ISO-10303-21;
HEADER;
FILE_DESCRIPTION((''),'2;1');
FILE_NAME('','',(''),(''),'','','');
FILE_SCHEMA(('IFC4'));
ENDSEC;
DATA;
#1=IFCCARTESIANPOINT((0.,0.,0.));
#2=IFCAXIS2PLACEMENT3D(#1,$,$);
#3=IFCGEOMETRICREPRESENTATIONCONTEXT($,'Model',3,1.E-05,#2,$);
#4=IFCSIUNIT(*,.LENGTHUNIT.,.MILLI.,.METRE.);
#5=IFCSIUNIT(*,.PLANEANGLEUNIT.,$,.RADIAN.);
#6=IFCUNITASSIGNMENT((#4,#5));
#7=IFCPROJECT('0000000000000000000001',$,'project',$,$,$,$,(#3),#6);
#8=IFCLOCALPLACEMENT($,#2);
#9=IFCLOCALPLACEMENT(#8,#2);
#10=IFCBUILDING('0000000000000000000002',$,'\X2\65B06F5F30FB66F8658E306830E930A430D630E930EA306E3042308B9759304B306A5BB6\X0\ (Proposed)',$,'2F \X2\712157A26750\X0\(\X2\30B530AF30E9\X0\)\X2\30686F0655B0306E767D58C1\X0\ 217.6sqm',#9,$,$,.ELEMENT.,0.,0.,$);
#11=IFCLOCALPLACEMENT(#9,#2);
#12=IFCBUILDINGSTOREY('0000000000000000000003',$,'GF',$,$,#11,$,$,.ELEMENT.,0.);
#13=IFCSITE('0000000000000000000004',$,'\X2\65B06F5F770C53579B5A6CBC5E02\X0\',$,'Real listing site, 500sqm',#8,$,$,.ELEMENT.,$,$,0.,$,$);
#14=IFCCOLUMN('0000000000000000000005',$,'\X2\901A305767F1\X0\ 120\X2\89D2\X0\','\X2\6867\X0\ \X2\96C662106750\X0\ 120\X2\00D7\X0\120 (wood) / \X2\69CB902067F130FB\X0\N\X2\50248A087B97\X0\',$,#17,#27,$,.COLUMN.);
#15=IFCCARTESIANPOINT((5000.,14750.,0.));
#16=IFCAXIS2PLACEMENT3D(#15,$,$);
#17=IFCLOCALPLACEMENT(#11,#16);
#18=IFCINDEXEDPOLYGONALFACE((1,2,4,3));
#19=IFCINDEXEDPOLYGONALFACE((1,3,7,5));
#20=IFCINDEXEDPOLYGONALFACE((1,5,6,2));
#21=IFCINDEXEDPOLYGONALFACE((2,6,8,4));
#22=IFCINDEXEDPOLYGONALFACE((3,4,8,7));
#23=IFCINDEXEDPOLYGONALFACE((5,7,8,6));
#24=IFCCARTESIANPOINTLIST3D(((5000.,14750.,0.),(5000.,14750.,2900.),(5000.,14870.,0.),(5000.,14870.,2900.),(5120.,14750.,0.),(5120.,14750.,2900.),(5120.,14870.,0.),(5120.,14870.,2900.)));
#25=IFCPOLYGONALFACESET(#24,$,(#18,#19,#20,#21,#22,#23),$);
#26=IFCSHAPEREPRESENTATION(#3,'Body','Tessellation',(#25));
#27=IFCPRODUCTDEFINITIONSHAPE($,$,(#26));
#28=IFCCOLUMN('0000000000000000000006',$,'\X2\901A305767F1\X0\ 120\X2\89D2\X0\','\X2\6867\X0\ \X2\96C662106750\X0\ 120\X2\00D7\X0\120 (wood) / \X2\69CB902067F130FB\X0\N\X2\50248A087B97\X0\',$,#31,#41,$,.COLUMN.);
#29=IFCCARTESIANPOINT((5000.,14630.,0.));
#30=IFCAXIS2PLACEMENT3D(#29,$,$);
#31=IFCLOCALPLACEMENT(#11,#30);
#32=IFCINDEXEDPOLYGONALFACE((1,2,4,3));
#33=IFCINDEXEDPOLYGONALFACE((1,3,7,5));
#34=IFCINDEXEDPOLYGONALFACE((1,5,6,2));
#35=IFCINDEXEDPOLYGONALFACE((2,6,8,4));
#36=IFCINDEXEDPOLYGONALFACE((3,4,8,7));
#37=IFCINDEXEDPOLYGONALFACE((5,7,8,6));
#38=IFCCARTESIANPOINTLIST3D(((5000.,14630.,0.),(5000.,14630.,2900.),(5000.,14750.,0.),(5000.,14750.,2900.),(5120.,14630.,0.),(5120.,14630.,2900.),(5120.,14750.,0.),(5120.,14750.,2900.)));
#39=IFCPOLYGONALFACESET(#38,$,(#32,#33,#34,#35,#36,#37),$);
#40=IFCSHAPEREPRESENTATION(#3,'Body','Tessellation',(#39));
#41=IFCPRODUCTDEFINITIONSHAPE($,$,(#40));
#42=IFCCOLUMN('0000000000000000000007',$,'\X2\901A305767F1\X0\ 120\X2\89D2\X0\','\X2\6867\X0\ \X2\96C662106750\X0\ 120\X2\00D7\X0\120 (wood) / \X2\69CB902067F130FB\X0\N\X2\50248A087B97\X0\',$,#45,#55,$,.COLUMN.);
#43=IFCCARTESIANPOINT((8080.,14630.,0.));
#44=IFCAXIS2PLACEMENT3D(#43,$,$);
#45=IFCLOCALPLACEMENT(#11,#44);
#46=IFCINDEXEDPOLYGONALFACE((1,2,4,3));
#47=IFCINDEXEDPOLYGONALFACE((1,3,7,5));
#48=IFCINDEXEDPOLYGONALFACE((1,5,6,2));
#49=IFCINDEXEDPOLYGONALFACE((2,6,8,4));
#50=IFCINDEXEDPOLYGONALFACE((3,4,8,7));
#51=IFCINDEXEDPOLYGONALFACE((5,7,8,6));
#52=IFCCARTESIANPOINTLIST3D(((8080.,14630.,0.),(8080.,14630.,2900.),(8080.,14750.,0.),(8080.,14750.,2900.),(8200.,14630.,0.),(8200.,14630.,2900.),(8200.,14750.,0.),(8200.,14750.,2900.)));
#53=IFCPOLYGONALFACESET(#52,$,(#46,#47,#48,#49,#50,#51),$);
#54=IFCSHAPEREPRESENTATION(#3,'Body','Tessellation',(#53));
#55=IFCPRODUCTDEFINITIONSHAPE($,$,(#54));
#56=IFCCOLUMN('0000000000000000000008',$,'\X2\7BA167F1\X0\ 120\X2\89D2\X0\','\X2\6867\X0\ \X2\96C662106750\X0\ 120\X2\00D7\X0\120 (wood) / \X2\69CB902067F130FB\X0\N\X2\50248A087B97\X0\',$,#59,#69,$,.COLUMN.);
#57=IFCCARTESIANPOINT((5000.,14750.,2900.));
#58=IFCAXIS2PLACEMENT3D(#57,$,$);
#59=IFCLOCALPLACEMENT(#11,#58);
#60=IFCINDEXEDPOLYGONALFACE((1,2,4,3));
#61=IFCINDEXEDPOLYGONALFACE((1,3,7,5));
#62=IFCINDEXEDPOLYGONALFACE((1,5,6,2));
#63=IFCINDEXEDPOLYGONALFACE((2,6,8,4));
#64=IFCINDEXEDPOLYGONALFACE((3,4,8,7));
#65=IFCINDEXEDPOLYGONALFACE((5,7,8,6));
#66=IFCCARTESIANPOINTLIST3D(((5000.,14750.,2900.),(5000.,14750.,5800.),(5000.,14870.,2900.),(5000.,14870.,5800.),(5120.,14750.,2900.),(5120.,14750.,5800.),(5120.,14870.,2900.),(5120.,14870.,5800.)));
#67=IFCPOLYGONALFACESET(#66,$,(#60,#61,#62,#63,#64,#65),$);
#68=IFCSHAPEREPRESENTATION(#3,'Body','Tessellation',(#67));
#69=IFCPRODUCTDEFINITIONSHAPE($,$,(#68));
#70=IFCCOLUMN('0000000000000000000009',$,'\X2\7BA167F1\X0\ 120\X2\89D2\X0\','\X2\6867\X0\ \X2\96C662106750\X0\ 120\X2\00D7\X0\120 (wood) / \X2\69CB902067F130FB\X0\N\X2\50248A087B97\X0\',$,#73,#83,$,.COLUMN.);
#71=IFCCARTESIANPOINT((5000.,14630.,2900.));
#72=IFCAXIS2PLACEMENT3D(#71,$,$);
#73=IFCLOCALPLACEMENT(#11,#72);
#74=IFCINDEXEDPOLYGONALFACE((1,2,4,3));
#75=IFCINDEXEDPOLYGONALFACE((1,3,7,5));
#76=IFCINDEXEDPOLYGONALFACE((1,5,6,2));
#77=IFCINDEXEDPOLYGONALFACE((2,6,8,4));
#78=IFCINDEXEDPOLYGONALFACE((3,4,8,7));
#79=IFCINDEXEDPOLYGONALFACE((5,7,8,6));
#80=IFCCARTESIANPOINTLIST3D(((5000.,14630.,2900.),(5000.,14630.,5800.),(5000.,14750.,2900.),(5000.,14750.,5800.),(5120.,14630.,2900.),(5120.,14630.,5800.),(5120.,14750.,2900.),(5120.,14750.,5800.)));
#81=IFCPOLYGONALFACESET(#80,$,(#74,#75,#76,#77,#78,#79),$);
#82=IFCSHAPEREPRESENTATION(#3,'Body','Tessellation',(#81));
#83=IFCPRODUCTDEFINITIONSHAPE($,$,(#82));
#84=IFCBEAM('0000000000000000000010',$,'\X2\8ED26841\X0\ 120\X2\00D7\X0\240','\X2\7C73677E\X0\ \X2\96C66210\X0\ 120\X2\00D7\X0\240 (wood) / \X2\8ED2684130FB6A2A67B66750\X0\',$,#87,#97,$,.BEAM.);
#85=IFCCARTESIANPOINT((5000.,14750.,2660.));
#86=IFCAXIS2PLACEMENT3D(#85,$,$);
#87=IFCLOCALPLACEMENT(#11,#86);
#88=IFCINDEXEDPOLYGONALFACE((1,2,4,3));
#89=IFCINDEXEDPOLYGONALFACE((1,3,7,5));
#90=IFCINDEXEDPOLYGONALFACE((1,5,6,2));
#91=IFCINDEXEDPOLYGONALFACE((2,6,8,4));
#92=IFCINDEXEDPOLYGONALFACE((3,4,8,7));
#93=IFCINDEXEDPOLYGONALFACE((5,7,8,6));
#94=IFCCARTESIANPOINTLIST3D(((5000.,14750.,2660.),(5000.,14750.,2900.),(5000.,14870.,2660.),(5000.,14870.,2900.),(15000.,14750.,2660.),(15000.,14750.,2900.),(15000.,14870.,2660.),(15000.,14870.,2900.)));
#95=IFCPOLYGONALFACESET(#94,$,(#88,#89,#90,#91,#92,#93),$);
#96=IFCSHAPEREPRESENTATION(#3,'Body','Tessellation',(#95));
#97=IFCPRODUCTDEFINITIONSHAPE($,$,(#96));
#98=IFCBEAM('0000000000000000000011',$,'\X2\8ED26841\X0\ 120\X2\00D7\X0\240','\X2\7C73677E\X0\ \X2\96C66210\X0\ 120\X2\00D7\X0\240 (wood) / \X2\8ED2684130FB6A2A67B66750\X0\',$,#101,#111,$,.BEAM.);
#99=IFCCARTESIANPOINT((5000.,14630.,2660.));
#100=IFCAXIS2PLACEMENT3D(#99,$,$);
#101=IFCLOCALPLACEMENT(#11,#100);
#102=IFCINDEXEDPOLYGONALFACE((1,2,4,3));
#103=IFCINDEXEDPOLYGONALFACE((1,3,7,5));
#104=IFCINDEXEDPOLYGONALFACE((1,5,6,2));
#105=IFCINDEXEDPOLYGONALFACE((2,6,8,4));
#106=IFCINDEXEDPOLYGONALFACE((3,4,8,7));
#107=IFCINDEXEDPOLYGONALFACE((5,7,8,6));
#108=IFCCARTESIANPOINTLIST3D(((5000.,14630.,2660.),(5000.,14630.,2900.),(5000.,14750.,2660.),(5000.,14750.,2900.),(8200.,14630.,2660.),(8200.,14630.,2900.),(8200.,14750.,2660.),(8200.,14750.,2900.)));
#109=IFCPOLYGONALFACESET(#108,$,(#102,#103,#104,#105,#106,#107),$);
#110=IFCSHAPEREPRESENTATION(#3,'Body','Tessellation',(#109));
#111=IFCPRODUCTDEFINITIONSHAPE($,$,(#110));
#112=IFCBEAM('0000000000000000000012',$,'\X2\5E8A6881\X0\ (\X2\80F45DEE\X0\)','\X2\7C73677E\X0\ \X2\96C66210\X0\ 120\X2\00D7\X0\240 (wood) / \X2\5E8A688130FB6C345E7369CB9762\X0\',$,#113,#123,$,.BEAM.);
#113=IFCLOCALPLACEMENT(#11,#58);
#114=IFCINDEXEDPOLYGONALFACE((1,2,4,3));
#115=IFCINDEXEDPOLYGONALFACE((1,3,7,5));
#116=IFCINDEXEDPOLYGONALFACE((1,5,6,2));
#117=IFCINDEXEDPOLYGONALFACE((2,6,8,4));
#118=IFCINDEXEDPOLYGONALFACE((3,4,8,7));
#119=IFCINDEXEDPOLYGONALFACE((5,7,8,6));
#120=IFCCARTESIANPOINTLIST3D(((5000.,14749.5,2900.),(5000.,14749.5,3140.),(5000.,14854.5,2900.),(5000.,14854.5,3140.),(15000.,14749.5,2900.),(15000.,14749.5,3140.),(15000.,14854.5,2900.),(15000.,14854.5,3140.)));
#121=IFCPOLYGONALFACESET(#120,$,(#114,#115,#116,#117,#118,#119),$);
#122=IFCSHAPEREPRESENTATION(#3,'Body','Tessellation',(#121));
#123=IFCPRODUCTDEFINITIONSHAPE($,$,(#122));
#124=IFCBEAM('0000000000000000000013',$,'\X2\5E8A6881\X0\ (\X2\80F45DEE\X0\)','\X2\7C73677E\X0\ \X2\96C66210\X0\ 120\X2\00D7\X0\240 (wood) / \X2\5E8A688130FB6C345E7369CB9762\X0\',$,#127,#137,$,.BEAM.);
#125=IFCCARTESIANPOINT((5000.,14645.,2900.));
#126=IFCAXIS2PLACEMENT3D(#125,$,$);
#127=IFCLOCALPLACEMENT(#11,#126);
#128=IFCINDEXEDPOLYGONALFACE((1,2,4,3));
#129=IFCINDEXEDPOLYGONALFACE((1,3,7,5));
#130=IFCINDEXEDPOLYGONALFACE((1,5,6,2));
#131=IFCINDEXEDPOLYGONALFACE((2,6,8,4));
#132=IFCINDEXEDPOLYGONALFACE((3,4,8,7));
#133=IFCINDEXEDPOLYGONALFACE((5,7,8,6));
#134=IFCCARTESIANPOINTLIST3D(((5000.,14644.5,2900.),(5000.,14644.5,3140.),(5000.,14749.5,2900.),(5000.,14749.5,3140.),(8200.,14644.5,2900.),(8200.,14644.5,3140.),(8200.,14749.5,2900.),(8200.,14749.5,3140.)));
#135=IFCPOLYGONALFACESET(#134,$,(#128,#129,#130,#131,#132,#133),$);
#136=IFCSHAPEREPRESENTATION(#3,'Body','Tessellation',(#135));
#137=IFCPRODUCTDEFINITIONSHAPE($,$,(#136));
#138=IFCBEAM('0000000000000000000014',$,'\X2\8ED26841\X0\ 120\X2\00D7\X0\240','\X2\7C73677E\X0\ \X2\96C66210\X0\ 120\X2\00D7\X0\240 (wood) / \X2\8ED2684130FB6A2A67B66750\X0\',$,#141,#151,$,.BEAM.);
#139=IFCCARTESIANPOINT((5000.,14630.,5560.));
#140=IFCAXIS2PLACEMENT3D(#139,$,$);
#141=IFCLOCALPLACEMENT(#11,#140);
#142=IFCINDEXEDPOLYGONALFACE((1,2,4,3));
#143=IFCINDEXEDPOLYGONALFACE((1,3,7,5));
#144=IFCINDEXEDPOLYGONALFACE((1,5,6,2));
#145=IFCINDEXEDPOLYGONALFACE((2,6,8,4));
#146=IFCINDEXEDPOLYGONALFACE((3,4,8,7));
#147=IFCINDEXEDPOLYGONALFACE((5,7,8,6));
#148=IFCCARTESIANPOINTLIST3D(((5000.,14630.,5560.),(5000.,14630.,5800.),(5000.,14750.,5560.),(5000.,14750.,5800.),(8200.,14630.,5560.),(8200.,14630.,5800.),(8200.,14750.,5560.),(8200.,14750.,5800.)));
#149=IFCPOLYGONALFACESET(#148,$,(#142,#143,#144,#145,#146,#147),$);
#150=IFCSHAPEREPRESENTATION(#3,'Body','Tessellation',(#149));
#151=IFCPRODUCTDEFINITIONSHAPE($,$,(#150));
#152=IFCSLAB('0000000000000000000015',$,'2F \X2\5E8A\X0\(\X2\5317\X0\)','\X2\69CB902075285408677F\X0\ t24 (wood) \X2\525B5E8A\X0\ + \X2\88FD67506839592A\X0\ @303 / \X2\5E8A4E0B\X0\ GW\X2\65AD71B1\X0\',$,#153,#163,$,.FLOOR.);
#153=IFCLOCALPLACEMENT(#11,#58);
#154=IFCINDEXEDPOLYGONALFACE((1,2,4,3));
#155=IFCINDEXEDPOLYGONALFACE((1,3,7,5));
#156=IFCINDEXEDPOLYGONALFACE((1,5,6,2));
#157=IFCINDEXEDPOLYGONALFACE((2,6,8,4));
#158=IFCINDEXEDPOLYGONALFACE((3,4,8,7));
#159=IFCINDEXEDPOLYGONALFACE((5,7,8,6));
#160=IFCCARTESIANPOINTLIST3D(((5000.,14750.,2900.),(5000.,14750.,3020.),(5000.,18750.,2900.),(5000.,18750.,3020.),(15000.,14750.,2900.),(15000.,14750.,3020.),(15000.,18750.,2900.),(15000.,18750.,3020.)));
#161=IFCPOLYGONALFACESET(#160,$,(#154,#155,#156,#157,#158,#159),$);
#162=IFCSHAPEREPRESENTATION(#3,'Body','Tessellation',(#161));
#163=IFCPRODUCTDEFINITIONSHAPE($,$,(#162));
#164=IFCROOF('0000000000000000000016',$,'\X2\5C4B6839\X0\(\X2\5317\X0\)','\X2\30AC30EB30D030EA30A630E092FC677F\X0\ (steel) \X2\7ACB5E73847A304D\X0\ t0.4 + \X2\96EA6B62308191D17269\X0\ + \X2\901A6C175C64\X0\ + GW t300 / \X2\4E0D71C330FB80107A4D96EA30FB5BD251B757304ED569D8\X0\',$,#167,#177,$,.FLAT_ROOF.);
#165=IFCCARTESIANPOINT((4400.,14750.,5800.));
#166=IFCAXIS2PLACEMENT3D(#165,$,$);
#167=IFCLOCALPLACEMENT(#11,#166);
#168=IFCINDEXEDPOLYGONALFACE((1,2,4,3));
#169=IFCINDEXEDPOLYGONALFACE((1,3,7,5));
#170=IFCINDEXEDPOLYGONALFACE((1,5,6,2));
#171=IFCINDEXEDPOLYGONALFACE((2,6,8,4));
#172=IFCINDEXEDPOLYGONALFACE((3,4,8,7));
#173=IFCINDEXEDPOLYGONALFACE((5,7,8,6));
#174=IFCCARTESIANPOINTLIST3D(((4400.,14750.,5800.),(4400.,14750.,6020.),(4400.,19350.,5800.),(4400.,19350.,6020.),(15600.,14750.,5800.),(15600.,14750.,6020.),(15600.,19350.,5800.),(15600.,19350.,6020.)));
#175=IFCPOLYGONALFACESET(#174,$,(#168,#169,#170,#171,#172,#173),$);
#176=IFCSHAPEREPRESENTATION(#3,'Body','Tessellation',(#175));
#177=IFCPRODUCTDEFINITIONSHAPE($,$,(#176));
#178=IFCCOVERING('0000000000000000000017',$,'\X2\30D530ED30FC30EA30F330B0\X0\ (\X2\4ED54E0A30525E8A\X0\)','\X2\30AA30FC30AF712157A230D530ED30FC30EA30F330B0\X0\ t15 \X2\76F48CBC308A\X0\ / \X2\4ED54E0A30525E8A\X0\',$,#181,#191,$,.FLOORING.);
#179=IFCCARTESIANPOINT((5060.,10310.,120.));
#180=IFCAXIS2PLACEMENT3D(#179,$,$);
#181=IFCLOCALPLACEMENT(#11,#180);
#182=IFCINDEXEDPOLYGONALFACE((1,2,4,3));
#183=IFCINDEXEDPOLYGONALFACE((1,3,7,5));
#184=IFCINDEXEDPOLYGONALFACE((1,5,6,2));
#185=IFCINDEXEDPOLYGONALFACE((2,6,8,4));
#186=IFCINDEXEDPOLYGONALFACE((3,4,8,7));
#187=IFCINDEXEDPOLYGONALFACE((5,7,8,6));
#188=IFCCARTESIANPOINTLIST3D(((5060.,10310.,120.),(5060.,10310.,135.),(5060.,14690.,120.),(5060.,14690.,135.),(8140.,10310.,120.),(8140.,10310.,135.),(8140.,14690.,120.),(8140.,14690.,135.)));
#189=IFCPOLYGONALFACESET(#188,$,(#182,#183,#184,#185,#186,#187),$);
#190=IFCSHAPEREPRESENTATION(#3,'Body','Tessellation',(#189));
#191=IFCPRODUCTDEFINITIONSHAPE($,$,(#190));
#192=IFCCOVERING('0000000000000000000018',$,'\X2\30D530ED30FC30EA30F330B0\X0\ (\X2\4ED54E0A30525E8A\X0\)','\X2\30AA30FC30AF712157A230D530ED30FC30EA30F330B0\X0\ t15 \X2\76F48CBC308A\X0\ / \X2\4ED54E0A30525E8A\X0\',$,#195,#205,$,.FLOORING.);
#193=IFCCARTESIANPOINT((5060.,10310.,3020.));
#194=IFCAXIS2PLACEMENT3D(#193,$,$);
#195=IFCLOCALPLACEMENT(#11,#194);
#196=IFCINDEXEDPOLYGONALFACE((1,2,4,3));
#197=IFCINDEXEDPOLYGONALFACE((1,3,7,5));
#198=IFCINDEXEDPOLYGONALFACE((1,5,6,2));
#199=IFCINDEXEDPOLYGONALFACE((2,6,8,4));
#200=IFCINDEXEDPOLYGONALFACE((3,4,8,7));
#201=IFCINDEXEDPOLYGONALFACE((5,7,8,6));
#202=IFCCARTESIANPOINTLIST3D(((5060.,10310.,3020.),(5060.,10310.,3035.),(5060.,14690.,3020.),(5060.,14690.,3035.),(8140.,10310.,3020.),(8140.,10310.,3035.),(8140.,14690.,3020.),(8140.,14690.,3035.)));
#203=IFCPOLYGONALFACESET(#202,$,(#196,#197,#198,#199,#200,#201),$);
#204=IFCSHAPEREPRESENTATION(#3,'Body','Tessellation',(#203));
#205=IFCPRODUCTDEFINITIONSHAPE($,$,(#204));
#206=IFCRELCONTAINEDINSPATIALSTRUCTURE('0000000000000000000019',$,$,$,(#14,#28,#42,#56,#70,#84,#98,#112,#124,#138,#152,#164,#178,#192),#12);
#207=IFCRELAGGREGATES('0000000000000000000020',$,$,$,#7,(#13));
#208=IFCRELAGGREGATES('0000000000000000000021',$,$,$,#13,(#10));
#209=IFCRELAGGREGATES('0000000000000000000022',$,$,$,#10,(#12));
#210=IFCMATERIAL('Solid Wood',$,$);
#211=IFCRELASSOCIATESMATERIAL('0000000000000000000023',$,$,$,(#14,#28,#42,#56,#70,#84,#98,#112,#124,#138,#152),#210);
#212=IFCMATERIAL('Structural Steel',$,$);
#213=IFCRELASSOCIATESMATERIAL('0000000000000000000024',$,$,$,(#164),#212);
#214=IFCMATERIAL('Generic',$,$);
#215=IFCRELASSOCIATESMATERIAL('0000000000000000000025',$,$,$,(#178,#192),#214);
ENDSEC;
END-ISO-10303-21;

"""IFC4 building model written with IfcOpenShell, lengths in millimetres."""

from ifc_helpers import new_model, si_unit, frame, frame_2d, origin, place, context, project, spatial, rectangle, extrude, material, element, save


model = new_model("IFC4")

# Units and contexts
model_context = context("Model", 3, precision=1e-05, world=origin())
ifc_project = project(units=[si_unit("LENGTHUNIT", "METRE", prefix="MILLI"), si_unit("PLANEANGLEUNIT", "RADIAN")], contexts=[model_context])

# Site, building, storey
site_placement = place(None, origin())
site = spatial("IfcSite", under=ifc_project, at=site_placement, Name="新潟県南魚沼市", ObjectType="Real listing site, 500sqm", CompositionType="ELEMENT", RefElevation=0.0)
building_placement = place(site_placement, origin())
building = spatial("IfcBuilding", under=site, at=building_placement, Name="新潟・書斎とライブラリのある静かな家 (Proposed)", ObjectType="2F 無垢材(サクラ)と漆喰の白壁 217.6sqm", CompositionType="ELEMENT", ElevationOfRefHeight=0.0, ElevationOfTerrain=0.0)
storey_placement = place(building_placement, origin())
storey = spatial("IfcBuildingStorey", under=building, at=storey_placement, Name="GF", CompositionType="ELEMENT", Elevation=0.0)

# Columns
ifc_material_1 = material(Name="Solid Wood")
column_1_placement = place(storey_placement, frame((5000.0, 14750.0, 0.0)))
element("IfcColumn", 1, at=column_1_placement, inside=storey, material=ifc_material_1, Name="通し柱 120角", Description="桧 集成材 120×120 (wood) / 構造柱・N値計算", PredefinedType="COLUMN", context=model_context, shape_type="SweptSolid", body=[
    extrude(rectangle(XDim=120.0, YDim=120.0, at=frame_2d((60.0, 60.0))), frame((5000.0, 14750.0, 0.0)), (0.0, 0.0, 1.0), 2900.0),
])
column_2_placement = place(storey_placement, frame((5000.0, 14630.0, 0.0)))
element("IfcColumn", 2, at=column_2_placement, inside=storey, material=ifc_material_1, Name="通し柱 120角", Description="桧 集成材 120×120 (wood) / 構造柱・N値計算", PredefinedType="COLUMN", context=model_context, shape_type="SweptSolid", body=[
    extrude(rectangle(XDim=120.0, YDim=120.0, at=frame_2d((60.0, 60.0))), frame((5000.0, 14630.0, 0.0)), (0.0, 0.0, 1.0), 2900.0),
])
column_3_placement = place(storey_placement, frame((8080.0, 14630.0, 0.0)))
element("IfcColumn", 3, at=column_3_placement, inside=storey, material=ifc_material_1, Name="通し柱 120角", Description="桧 集成材 120×120 (wood) / 構造柱・N値計算", PredefinedType="COLUMN", context=model_context, shape_type="SweptSolid", body=[
    extrude(rectangle(XDim=120.0, YDim=120.0, at=frame_2d((60.0, 60.0))), frame((8080.0, 14630.0, 0.0)), (0.0, 0.0, 1.0), 2900.0),
])
column_4_placement = place(storey_placement, frame((5000.0, 14750.0, 2900.0)))
element("IfcColumn", 4, at=column_4_placement, inside=storey, material=ifc_material_1, Name="管柱 120角", Description="桧 集成材 120×120 (wood) / 構造柱・N値計算", PredefinedType="COLUMN", context=model_context, shape_type="SweptSolid", body=[
    extrude(rectangle(XDim=120.0, YDim=120.0, at=frame_2d((60.0, 60.0))), frame((5000.0, 14750.0, 2900.0)), (0.0, 0.0, 1.0), 2900.0),
])
column_5_placement = place(storey_placement, frame((5000.0, 14630.0, 2900.0)))
element("IfcColumn", 5, at=column_5_placement, inside=storey, material=ifc_material_1, Name="管柱 120角", Description="桧 集成材 120×120 (wood) / 構造柱・N値計算", PredefinedType="COLUMN", context=model_context, shape_type="SweptSolid", body=[
    extrude(rectangle(XDim=120.0, YDim=120.0, at=frame_2d((60.0, 60.0))), frame((5000.0, 14630.0, 2900.0)), (0.0, 0.0, 1.0), 2900.0),
])

# Beams
beam_1_placement = place(storey_placement, frame((5000.0, 14750.0, 2660.0)))
element("IfcBeam", 6, at=beam_1_placement, inside=storey, material=ifc_material_1, Name="軒桁 120×240", Description="米松 集成 120×240 (wood) / 軒桁・横架材", PredefinedType="BEAM", context=model_context, shape_type="SweptSolid", body=[
    extrude(rectangle(XDim=10000.0, YDim=120.0, at=frame_2d((5000.0, 60.0))), frame((5000.0, 14750.0, 2660.0)), (0.0, 0.0, 1.0), 240.0),
])
beam_2_placement = place(storey_placement, frame((5000.0, 14630.0, 2660.0)))
element("IfcBeam", 7, at=beam_2_placement, inside=storey, material=ifc_material_1, Name="軒桁 120×240", Description="米松 集成 120×240 (wood) / 軒桁・横架材", PredefinedType="BEAM", context=model_context, shape_type="SweptSolid", body=[
    extrude(rectangle(XDim=3200.0, YDim=120.0, at=frame_2d((1600.0, 60.0))), frame((5000.0, 14630.0, 2660.0)), (0.0, 0.0, 1.0), 240.0),
])
beam_3_placement = place(storey_placement, frame((5000.0, 14750.0, 2900.0)))
element("IfcBeam", 8, at=beam_3_placement, inside=storey, material=ifc_material_1, Name="床梁 (胴差)", Description="米松 集成 120×240 (wood) / 床梁・水平構面", PredefinedType="BEAM", context=model_context, shape_type="SweptSolid", body=[
    extrude(rectangle(XDim=10000.0, YDim=105.0, at=frame_2d((5000.0, 52.0))), frame((5000.0, 14750.0, 2900.0)), (0.0, 0.0, 1.0), 240.0),
])
beam_4_placement = place(storey_placement, frame((5000.0, 14645.0, 2900.0)))
element("IfcBeam", 9, at=beam_4_placement, inside=storey, material=ifc_material_1, Name="床梁 (胴差)", Description="米松 集成 120×240 (wood) / 床梁・水平構面", PredefinedType="BEAM", context=model_context, shape_type="SweptSolid", body=[
    extrude(rectangle(XDim=3200.0, YDim=105.0, at=frame_2d((1600.0, 52.0))), frame((5000.0, 14645.0, 2900.0)), (0.0, 0.0, 1.0), 240.0),
])
beam_5_placement = place(storey_placement, frame((5000.0, 14630.0, 5560.0)))
element("IfcBeam", 10, at=beam_5_placement, inside=storey, material=ifc_material_1, Name="軒桁 120×240", Description="米松 集成 120×240 (wood) / 軒桁・横架材", PredefinedType="BEAM", context=model_context, shape_type="SweptSolid", body=[
    extrude(rectangle(XDim=3200.0, YDim=120.0, at=frame_2d((1600.0, 60.0))), frame((5000.0, 14630.0, 5560.0)), (0.0, 0.0, 1.0), 240.0),
])

# Slab
slab_1_placement = place(storey_placement, frame((5000.0, 14750.0, 2900.0)))
element("IfcSlab", 11, at=slab_1_placement, inside=storey, material=ifc_material_1, Name="2F 床(北)", Description="構造用合板 t24 (wood) 剛床 + 製材根太 @303 / 床下 GW断熱", PredefinedType="FLOOR", context=model_context, shape_type="SweptSolid", body=[
    extrude(rectangle(XDim=10000.0, YDim=4000.0, at=frame_2d((5000.0, 2000.0))), frame((5000.0, 14750.0, 2900.0)), (0.0, 0.0, 1.0), 120.0),
])

# Roof
ifc_material_2 = material(Name="Structural Steel")
for number, where, name in (
    (12, (4400.0, 14750.0, 5800.0), "屋根(北)"),
):
    element("IfcRoof", number, at=place(storey_placement, frame(where)), inside=storey, material=ifc_material_2, Name=name, Description="ガルバリウム鋼板 (steel) 立平葺き t0.4 + 雪止め金物 + 通気層 + GW t300 / 不燃・耐積雪・寒冷地仕様", PredefinedType="FLAT_ROOF", context=model_context, shape_type="SweptSolid", body=[
        extrude(rectangle(XDim=11200.0, YDim=4600.0, at=frame_2d((5600.0, 2300.0))), frame((4400.0, 14750.0, 5800.0)), (0.0, 0.0, 1.0), 220.0),
    ])

# Coverings
ifc_material_3 = material(Name="Generic")
covering_1_placement = place(storey_placement, frame((5060.0, 10310.0, 120.0)))
element("IfcCovering", 13, at=covering_1_placement, inside=storey, material=ifc_material_3, Name="フローリング (仕上げ床)", Description="オーク無垢フローリング t15 直貼り / 仕上げ床", PredefinedType="FLOORING", context=model_context, shape_type="SweptSolid", body=[
    extrude(rectangle(XDim=3080.0, YDim=4380.0, at=frame_2d((1540.0, 2190.0))), frame((5060.0, 10310.0, 120.0)), (0.0, 0.0, 1.0), 15.0),
])
covering_2_placement = place(storey_placement, frame((5060.0, 10310.0, 3020.0)))
element("IfcCovering", 14, at=covering_2_placement, inside=storey, material=ifc_material_3, Name="フローリング (仕上げ床)", Description="オーク無垢フローリング t15 直貼り / 仕上げ床", PredefinedType="FLOORING", context=model_context, shape_type="SweptSolid", body=[
    extrude(rectangle(XDim=3080.0, YDim=4380.0, at=frame_2d((1540.0, 2190.0))), frame((5060.0, 10310.0, 3020.0)), (0.0, 0.0, 1.0), 15.0),
])

save(model, "model.ifc")
